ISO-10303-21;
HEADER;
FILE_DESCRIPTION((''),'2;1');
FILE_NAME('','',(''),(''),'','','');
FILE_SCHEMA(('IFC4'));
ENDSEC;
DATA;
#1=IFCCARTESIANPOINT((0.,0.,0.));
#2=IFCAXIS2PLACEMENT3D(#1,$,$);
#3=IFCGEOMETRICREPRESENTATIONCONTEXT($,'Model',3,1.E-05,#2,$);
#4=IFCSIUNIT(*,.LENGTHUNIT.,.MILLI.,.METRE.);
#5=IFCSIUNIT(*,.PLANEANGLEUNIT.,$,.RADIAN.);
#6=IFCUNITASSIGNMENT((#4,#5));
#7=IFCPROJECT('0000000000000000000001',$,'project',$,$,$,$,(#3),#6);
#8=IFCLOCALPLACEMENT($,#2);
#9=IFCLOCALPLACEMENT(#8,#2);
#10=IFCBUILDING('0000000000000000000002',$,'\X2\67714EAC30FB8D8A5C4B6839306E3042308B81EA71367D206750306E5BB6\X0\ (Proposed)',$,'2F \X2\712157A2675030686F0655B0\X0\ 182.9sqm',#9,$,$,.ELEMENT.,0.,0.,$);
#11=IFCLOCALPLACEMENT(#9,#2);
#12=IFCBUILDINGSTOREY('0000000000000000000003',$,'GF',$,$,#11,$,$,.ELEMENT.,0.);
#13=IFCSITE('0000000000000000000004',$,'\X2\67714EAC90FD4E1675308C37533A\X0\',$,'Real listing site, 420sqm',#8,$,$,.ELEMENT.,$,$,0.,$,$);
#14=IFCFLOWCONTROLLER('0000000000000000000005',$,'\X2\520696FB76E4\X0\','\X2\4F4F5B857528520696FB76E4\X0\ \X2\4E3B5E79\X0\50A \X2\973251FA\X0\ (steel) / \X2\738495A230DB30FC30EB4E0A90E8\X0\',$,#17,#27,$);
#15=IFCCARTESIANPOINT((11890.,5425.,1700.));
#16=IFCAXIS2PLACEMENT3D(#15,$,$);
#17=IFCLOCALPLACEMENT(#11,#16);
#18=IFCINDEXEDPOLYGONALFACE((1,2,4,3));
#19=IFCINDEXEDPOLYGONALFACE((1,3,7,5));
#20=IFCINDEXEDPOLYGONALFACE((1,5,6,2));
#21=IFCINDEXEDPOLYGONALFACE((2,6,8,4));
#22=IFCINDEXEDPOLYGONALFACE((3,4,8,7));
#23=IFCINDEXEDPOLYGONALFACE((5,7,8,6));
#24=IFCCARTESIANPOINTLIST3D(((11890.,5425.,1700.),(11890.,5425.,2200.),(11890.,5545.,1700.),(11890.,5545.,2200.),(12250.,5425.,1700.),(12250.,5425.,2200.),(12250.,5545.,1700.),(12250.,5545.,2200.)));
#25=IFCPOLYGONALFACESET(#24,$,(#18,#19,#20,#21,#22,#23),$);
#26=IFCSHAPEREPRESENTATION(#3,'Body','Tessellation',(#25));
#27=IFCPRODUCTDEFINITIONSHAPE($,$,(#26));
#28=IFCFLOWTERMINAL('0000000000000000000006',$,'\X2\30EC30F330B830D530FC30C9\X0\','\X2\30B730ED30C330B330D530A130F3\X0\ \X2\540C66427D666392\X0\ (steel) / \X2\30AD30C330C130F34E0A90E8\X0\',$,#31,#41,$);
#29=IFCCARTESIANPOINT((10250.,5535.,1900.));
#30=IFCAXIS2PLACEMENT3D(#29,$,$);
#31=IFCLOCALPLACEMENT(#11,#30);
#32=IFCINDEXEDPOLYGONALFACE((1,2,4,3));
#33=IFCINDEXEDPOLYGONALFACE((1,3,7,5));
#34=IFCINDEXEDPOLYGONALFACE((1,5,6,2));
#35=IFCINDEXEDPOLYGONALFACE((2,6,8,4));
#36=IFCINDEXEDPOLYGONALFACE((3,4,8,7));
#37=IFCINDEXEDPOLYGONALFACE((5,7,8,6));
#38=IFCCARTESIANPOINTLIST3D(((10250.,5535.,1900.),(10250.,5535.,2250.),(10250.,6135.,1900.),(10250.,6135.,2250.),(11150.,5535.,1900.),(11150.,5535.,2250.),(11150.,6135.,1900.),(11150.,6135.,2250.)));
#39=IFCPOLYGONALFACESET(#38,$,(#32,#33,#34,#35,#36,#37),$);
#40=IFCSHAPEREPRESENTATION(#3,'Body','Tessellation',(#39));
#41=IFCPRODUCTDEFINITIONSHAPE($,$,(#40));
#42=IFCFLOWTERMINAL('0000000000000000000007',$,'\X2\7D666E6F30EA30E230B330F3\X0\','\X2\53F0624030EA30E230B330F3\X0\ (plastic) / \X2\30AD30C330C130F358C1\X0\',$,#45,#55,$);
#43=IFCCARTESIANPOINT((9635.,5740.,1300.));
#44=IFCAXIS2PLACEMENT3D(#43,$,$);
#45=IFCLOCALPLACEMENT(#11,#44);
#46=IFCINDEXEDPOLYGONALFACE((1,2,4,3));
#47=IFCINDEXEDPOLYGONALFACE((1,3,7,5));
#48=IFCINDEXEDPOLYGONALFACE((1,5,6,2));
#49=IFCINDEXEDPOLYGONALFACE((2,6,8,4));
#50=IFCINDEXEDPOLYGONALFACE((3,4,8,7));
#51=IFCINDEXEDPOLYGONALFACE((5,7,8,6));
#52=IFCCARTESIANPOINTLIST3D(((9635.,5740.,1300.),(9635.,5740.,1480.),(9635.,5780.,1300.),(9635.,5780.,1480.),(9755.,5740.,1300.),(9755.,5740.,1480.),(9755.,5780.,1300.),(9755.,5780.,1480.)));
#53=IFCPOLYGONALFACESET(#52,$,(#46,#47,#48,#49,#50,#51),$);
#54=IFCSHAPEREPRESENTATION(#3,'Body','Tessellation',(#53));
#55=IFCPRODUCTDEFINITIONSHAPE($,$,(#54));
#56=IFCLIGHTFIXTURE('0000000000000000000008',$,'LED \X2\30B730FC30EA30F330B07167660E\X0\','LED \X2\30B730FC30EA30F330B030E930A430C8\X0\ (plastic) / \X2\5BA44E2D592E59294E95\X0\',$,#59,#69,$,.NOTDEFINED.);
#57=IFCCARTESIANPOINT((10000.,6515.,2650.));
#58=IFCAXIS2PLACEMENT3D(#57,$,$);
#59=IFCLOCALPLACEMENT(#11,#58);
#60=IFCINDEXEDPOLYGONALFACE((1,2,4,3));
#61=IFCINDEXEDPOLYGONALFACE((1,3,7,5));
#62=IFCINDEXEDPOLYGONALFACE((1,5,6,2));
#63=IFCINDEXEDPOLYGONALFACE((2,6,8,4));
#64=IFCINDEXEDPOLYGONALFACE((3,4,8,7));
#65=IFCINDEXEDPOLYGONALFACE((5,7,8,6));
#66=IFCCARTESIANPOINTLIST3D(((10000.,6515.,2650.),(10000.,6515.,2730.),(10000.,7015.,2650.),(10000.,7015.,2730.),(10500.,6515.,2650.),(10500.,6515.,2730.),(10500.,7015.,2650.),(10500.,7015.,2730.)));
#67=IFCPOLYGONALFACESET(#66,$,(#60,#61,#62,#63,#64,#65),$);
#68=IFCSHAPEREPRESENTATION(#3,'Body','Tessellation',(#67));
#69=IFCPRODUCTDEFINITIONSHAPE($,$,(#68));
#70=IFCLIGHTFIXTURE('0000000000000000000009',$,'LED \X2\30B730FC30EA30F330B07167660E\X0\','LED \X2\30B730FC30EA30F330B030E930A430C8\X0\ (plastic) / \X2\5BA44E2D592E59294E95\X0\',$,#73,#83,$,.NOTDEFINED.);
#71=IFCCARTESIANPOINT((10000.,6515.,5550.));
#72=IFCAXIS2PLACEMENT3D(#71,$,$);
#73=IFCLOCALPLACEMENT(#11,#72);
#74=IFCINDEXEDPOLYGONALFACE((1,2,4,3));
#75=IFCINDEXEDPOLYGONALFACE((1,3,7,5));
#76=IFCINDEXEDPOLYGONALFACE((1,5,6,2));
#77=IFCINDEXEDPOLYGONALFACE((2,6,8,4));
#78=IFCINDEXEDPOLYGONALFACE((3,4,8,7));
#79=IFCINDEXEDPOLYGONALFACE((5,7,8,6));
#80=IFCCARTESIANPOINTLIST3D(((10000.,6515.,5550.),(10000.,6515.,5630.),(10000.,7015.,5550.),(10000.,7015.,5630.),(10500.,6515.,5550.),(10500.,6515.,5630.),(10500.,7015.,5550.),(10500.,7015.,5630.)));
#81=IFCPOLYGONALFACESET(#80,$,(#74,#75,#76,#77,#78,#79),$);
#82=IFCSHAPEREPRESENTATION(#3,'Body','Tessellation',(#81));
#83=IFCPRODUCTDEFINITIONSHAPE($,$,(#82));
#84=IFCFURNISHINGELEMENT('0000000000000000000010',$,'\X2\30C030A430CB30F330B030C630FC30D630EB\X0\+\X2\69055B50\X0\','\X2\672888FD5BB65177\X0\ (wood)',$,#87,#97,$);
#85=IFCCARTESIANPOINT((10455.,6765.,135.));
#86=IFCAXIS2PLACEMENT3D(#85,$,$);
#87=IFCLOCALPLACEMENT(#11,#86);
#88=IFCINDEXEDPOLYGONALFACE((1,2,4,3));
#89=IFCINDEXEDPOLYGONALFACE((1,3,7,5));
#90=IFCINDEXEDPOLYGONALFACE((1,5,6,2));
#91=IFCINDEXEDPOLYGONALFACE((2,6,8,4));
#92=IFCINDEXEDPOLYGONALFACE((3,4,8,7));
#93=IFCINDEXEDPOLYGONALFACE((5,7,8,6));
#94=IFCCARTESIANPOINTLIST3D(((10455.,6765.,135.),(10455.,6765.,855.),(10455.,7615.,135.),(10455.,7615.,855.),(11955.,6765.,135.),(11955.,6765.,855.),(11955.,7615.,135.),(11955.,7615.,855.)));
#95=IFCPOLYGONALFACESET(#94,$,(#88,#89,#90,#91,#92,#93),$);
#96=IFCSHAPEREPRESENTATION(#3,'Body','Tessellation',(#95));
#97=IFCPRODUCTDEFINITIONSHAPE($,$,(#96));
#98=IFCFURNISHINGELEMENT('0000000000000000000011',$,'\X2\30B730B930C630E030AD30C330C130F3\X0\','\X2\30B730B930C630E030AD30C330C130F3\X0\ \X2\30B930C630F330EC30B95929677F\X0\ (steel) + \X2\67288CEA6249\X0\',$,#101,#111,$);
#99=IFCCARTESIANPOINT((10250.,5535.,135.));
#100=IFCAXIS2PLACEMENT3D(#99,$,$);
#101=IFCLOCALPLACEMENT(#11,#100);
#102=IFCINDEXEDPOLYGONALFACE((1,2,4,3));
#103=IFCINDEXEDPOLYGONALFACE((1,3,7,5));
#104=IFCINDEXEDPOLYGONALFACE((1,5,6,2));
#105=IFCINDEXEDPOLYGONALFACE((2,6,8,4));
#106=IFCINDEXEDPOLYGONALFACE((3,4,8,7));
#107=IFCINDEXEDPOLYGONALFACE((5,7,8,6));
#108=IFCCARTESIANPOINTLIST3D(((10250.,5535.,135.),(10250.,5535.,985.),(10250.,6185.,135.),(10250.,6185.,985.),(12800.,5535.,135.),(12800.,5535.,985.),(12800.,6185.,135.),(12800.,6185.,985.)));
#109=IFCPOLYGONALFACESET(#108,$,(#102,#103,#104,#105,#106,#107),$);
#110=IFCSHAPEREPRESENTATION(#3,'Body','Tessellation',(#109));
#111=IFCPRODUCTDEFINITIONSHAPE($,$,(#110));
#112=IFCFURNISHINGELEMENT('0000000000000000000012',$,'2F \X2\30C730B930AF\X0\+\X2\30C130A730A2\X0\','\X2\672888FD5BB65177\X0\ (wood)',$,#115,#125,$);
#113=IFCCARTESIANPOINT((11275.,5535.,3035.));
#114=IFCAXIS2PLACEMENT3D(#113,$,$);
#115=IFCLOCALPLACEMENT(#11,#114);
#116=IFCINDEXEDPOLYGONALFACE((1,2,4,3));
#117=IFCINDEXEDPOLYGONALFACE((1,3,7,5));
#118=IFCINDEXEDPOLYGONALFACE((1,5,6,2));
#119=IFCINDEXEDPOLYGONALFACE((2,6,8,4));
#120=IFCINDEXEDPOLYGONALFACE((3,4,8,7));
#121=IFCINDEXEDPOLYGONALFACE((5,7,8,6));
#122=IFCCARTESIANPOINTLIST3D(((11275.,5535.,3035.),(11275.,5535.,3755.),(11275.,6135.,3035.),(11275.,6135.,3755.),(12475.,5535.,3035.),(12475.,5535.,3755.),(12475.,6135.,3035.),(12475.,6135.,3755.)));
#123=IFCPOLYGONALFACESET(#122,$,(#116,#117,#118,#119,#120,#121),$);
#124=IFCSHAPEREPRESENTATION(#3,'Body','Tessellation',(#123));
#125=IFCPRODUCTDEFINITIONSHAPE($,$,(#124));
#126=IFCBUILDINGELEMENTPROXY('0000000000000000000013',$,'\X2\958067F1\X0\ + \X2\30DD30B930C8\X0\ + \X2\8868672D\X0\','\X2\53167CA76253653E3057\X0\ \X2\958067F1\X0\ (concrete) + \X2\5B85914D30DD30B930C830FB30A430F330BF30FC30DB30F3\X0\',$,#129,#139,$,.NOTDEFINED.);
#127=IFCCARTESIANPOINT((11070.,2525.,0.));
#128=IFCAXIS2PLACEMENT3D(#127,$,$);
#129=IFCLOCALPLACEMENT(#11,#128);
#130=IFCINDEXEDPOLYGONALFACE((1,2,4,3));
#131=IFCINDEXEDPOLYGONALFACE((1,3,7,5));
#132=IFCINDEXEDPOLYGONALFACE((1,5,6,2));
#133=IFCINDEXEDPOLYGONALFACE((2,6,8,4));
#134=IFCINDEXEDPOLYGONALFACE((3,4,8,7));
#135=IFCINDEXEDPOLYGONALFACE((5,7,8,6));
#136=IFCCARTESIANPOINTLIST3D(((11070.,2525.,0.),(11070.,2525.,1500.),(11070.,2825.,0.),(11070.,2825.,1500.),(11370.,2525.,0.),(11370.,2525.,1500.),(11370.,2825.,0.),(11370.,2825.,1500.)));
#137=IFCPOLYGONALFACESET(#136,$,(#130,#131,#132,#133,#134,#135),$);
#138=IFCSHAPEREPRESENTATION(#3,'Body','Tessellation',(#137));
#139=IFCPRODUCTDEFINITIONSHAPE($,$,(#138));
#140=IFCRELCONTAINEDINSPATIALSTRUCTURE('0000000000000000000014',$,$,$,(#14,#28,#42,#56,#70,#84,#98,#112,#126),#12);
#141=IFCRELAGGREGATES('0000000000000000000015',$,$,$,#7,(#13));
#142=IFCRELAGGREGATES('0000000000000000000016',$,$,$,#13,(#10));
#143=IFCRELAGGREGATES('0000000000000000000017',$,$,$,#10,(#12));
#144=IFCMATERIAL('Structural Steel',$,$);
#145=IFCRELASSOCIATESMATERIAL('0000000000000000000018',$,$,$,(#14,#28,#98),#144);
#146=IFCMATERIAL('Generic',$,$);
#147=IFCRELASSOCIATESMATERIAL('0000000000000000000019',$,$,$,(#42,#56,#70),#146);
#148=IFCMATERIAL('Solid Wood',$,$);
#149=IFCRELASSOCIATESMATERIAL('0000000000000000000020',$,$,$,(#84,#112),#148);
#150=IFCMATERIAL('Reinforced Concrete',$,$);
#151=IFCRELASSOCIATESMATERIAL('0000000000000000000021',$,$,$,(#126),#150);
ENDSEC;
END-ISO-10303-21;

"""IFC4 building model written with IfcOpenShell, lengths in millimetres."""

from ifc_helpers import new_model, si_unit, frame, frame_2d, origin, place, context, project, spatial, rectangle, extrude, material, element, save


model = new_model("IFC4")

# Units and contexts
model_context = context("Model", 3, precision=1e-05, world=origin())
ifc_project = project(units=[si_unit("LENGTHUNIT", "METRE", prefix="MILLI"), si_unit("PLANEANGLEUNIT", "RADIAN")], contexts=[model_context])

# Site, building, storey
site_placement = place(None, origin())
site = spatial("IfcSite", under=ifc_project, at=site_placement, Name="東京都世田谷区", ObjectType="Real listing site, 420sqm", CompositionType="ELEMENT", RefElevation=0.0)
building_placement = place(site_placement, origin())
building = spatial("IfcBuilding", under=site, at=building_placement, Name="東京・越屋根のある自然素材の家 (Proposed)", ObjectType="2F 無垢材と漆喰 182.9sqm", CompositionType="ELEMENT", ElevationOfRefHeight=0.0, ElevationOfTerrain=0.0)
storey_placement = place(building_placement, origin())
storey = spatial("IfcBuildingStorey", under=building, at=storey_placement, Name="GF", CompositionType="ELEMENT", Elevation=0.0)

# Shared definitions
ifc_material_1 = material(Name="Solid Wood")

# Shared definitions
ifc_material_2 = material(Name="Structural Steel")

# Shared definitions
ifc_material_3 = material(Name="Reinforced Concrete")

# Flow controller
flow_controller_placement = place(storey_placement, frame((11890.0, 5425.0, 1700.0)))
element("IfcFlowController", 1, at=flow_controller_placement, inside=storey, material=ifc_material_2, Name="分電盤", Description="住宅用分電盤 主幹50A 露出 (steel) / 玄関ホール上部", context=model_context, shape_type="SweptSolid", body=[
    extrude(rectangle(XDim=360.0, YDim=120.0, at=frame_2d((180.0, 60.0))), frame((11890.0, 5425.0, 1700.0)), (0.0, 0.0, 1.0), 500.0),
])

# Flow terminals
flow_terminal_1_placement = place(storey_placement, frame((10250.0, 5535.0, 1900.0)))
element("IfcFlowTerminal", 2, at=flow_terminal_1_placement, inside=storey, material=ifc_material_2, Name="レンジフード", Description="シロッコファン 同時給排 (steel) / キッチン上部", context=model_context, shape_type="SweptSolid", body=[
    extrude(rectangle(XDim=900.0, YDim=600.0, at=frame_2d((450.0, 300.0))), frame((10250.0, 5535.0, 1900.0)), (0.0, 0.0, 1.0), 350.0),
])
ifc_material_4 = material(Name="Generic")
flow_terminal_2_placement = place(storey_placement, frame((9635.0, 5740.0, 1300.0)))
element("IfcFlowTerminal", 3, at=flow_terminal_2_placement, inside=storey, material=ifc_material_4, Name="給湯リモコン", Description="台所リモコン (plastic) / キッチン壁", context=model_context, shape_type="SweptSolid", body=[
    extrude(rectangle(XDim=120.0, YDim=40.0, at=frame_2d((60.0, 20.0))), frame((9635.0, 5740.0, 1300.0)), (0.0, 0.0, 1.0), 180.0),
])

# Light fixtures
light_fixture_1_placement = place(storey_placement, frame((10000.0, 6515.0, 2650.0)))
element("IfcLightFixture", 4, at=light_fixture_1_placement, inside=storey, material=ifc_material_4, Name="LED シーリング照明", Description="LED シーリングライト (plastic) / 室中央天井", PredefinedType="NOTDEFINED", context=model_context, shape_type="SweptSolid", body=[
    extrude(rectangle(XDim=500.0, YDim=500.0, at=frame_2d((250.0, 250.0))), frame((10000.0, 6515.0, 2650.0)), (0.0, 0.0, 1.0), 80.0),
])
light_fixture_2_placement = place(storey_placement, frame((10000.0, 6515.0, 5550.0)))
element("IfcLightFixture", 5, at=light_fixture_2_placement, inside=storey, material=ifc_material_4, Name="LED シーリング照明", Description="LED シーリングライト (plastic) / 室中央天井", PredefinedType="NOTDEFINED", context=model_context, shape_type="SweptSolid", body=[
    extrude(rectangle(XDim=500.0, YDim=500.0, at=frame_2d((250.0, 250.0))), frame((10000.0, 6515.0, 5550.0)), (0.0, 0.0, 1.0), 80.0),
])

# Furnishing elements
furnishing_1_placement = place(storey_placement, frame((10455.0, 6765.0, 135.0)))
element("IfcFurnishingElement", 6, at=furnishing_1_placement, inside=storey, material=ifc_material_1, Name="ダイニングテーブル+椅子", Description="木製家具 (wood)", context=model_context, shape_type="SweptSolid", body=[
    extrude(rectangle(XDim=1500.0, YDim=850.0, at=frame_2d((750.0, 425.0))), frame((10455.0, 6765.0, 135.0)), (0.0, 0.0, 1.0), 720.0),
])
furnishing_2_placement = place(storey_placement, frame((10250.0, 5535.0, 135.0)))
element("IfcFurnishingElement", 7, at=furnishing_2_placement, inside=storey, material=ifc_material_2, Name="システムキッチン", Description="システムキッチン ステンレス天板 (steel) + 木質扉", context=model_context, shape_type="SweptSolid", body=[
    extrude(rectangle(XDim=2550.0, YDim=650.0, at=frame_2d((1275.0, 325.0))), frame((10250.0, 5535.0, 135.0)), (0.0, 0.0, 1.0), 850.0),
])
furnishing_3_placement = place(storey_placement, frame((11275.0, 5535.0, 3035.0)))
element("IfcFurnishingElement", 8, at=furnishing_3_placement, inside=storey, material=ifc_material_1, Name="2F デスク+チェア", Description="木製家具 (wood)", context=model_context, shape_type="SweptSolid", body=[
    extrude(rectangle(XDim=1200.0, YDim=600.0, at=frame_2d((600.0, 300.0))), frame((11275.0, 5535.0, 3035.0)), (0.0, 0.0, 1.0), 720.0),
])

# Building element proxy
proxy_placement = place(storey_placement, frame((11070.0, 2525.0, 0.0)))
element("IfcBuildingElementProxy", 9, at=proxy_placement, inside=storey, material=ifc_material_3, Name="門柱 + ポスト + 表札", Description="化粧打放し 門柱 (concrete) + 宅配ポスト・インターホン", PredefinedType="NOTDEFINED", context=model_context, shape_type="SweptSolid", body=[
    extrude(rectangle(XDim=300.0, YDim=300.0, at=frame_2d((150.0, 150.0))), frame((11070.0, 2525.0, 0.0)), (0.0, 0.0, 1.0), 1500.0),
])

save(model, "model.ifc")
